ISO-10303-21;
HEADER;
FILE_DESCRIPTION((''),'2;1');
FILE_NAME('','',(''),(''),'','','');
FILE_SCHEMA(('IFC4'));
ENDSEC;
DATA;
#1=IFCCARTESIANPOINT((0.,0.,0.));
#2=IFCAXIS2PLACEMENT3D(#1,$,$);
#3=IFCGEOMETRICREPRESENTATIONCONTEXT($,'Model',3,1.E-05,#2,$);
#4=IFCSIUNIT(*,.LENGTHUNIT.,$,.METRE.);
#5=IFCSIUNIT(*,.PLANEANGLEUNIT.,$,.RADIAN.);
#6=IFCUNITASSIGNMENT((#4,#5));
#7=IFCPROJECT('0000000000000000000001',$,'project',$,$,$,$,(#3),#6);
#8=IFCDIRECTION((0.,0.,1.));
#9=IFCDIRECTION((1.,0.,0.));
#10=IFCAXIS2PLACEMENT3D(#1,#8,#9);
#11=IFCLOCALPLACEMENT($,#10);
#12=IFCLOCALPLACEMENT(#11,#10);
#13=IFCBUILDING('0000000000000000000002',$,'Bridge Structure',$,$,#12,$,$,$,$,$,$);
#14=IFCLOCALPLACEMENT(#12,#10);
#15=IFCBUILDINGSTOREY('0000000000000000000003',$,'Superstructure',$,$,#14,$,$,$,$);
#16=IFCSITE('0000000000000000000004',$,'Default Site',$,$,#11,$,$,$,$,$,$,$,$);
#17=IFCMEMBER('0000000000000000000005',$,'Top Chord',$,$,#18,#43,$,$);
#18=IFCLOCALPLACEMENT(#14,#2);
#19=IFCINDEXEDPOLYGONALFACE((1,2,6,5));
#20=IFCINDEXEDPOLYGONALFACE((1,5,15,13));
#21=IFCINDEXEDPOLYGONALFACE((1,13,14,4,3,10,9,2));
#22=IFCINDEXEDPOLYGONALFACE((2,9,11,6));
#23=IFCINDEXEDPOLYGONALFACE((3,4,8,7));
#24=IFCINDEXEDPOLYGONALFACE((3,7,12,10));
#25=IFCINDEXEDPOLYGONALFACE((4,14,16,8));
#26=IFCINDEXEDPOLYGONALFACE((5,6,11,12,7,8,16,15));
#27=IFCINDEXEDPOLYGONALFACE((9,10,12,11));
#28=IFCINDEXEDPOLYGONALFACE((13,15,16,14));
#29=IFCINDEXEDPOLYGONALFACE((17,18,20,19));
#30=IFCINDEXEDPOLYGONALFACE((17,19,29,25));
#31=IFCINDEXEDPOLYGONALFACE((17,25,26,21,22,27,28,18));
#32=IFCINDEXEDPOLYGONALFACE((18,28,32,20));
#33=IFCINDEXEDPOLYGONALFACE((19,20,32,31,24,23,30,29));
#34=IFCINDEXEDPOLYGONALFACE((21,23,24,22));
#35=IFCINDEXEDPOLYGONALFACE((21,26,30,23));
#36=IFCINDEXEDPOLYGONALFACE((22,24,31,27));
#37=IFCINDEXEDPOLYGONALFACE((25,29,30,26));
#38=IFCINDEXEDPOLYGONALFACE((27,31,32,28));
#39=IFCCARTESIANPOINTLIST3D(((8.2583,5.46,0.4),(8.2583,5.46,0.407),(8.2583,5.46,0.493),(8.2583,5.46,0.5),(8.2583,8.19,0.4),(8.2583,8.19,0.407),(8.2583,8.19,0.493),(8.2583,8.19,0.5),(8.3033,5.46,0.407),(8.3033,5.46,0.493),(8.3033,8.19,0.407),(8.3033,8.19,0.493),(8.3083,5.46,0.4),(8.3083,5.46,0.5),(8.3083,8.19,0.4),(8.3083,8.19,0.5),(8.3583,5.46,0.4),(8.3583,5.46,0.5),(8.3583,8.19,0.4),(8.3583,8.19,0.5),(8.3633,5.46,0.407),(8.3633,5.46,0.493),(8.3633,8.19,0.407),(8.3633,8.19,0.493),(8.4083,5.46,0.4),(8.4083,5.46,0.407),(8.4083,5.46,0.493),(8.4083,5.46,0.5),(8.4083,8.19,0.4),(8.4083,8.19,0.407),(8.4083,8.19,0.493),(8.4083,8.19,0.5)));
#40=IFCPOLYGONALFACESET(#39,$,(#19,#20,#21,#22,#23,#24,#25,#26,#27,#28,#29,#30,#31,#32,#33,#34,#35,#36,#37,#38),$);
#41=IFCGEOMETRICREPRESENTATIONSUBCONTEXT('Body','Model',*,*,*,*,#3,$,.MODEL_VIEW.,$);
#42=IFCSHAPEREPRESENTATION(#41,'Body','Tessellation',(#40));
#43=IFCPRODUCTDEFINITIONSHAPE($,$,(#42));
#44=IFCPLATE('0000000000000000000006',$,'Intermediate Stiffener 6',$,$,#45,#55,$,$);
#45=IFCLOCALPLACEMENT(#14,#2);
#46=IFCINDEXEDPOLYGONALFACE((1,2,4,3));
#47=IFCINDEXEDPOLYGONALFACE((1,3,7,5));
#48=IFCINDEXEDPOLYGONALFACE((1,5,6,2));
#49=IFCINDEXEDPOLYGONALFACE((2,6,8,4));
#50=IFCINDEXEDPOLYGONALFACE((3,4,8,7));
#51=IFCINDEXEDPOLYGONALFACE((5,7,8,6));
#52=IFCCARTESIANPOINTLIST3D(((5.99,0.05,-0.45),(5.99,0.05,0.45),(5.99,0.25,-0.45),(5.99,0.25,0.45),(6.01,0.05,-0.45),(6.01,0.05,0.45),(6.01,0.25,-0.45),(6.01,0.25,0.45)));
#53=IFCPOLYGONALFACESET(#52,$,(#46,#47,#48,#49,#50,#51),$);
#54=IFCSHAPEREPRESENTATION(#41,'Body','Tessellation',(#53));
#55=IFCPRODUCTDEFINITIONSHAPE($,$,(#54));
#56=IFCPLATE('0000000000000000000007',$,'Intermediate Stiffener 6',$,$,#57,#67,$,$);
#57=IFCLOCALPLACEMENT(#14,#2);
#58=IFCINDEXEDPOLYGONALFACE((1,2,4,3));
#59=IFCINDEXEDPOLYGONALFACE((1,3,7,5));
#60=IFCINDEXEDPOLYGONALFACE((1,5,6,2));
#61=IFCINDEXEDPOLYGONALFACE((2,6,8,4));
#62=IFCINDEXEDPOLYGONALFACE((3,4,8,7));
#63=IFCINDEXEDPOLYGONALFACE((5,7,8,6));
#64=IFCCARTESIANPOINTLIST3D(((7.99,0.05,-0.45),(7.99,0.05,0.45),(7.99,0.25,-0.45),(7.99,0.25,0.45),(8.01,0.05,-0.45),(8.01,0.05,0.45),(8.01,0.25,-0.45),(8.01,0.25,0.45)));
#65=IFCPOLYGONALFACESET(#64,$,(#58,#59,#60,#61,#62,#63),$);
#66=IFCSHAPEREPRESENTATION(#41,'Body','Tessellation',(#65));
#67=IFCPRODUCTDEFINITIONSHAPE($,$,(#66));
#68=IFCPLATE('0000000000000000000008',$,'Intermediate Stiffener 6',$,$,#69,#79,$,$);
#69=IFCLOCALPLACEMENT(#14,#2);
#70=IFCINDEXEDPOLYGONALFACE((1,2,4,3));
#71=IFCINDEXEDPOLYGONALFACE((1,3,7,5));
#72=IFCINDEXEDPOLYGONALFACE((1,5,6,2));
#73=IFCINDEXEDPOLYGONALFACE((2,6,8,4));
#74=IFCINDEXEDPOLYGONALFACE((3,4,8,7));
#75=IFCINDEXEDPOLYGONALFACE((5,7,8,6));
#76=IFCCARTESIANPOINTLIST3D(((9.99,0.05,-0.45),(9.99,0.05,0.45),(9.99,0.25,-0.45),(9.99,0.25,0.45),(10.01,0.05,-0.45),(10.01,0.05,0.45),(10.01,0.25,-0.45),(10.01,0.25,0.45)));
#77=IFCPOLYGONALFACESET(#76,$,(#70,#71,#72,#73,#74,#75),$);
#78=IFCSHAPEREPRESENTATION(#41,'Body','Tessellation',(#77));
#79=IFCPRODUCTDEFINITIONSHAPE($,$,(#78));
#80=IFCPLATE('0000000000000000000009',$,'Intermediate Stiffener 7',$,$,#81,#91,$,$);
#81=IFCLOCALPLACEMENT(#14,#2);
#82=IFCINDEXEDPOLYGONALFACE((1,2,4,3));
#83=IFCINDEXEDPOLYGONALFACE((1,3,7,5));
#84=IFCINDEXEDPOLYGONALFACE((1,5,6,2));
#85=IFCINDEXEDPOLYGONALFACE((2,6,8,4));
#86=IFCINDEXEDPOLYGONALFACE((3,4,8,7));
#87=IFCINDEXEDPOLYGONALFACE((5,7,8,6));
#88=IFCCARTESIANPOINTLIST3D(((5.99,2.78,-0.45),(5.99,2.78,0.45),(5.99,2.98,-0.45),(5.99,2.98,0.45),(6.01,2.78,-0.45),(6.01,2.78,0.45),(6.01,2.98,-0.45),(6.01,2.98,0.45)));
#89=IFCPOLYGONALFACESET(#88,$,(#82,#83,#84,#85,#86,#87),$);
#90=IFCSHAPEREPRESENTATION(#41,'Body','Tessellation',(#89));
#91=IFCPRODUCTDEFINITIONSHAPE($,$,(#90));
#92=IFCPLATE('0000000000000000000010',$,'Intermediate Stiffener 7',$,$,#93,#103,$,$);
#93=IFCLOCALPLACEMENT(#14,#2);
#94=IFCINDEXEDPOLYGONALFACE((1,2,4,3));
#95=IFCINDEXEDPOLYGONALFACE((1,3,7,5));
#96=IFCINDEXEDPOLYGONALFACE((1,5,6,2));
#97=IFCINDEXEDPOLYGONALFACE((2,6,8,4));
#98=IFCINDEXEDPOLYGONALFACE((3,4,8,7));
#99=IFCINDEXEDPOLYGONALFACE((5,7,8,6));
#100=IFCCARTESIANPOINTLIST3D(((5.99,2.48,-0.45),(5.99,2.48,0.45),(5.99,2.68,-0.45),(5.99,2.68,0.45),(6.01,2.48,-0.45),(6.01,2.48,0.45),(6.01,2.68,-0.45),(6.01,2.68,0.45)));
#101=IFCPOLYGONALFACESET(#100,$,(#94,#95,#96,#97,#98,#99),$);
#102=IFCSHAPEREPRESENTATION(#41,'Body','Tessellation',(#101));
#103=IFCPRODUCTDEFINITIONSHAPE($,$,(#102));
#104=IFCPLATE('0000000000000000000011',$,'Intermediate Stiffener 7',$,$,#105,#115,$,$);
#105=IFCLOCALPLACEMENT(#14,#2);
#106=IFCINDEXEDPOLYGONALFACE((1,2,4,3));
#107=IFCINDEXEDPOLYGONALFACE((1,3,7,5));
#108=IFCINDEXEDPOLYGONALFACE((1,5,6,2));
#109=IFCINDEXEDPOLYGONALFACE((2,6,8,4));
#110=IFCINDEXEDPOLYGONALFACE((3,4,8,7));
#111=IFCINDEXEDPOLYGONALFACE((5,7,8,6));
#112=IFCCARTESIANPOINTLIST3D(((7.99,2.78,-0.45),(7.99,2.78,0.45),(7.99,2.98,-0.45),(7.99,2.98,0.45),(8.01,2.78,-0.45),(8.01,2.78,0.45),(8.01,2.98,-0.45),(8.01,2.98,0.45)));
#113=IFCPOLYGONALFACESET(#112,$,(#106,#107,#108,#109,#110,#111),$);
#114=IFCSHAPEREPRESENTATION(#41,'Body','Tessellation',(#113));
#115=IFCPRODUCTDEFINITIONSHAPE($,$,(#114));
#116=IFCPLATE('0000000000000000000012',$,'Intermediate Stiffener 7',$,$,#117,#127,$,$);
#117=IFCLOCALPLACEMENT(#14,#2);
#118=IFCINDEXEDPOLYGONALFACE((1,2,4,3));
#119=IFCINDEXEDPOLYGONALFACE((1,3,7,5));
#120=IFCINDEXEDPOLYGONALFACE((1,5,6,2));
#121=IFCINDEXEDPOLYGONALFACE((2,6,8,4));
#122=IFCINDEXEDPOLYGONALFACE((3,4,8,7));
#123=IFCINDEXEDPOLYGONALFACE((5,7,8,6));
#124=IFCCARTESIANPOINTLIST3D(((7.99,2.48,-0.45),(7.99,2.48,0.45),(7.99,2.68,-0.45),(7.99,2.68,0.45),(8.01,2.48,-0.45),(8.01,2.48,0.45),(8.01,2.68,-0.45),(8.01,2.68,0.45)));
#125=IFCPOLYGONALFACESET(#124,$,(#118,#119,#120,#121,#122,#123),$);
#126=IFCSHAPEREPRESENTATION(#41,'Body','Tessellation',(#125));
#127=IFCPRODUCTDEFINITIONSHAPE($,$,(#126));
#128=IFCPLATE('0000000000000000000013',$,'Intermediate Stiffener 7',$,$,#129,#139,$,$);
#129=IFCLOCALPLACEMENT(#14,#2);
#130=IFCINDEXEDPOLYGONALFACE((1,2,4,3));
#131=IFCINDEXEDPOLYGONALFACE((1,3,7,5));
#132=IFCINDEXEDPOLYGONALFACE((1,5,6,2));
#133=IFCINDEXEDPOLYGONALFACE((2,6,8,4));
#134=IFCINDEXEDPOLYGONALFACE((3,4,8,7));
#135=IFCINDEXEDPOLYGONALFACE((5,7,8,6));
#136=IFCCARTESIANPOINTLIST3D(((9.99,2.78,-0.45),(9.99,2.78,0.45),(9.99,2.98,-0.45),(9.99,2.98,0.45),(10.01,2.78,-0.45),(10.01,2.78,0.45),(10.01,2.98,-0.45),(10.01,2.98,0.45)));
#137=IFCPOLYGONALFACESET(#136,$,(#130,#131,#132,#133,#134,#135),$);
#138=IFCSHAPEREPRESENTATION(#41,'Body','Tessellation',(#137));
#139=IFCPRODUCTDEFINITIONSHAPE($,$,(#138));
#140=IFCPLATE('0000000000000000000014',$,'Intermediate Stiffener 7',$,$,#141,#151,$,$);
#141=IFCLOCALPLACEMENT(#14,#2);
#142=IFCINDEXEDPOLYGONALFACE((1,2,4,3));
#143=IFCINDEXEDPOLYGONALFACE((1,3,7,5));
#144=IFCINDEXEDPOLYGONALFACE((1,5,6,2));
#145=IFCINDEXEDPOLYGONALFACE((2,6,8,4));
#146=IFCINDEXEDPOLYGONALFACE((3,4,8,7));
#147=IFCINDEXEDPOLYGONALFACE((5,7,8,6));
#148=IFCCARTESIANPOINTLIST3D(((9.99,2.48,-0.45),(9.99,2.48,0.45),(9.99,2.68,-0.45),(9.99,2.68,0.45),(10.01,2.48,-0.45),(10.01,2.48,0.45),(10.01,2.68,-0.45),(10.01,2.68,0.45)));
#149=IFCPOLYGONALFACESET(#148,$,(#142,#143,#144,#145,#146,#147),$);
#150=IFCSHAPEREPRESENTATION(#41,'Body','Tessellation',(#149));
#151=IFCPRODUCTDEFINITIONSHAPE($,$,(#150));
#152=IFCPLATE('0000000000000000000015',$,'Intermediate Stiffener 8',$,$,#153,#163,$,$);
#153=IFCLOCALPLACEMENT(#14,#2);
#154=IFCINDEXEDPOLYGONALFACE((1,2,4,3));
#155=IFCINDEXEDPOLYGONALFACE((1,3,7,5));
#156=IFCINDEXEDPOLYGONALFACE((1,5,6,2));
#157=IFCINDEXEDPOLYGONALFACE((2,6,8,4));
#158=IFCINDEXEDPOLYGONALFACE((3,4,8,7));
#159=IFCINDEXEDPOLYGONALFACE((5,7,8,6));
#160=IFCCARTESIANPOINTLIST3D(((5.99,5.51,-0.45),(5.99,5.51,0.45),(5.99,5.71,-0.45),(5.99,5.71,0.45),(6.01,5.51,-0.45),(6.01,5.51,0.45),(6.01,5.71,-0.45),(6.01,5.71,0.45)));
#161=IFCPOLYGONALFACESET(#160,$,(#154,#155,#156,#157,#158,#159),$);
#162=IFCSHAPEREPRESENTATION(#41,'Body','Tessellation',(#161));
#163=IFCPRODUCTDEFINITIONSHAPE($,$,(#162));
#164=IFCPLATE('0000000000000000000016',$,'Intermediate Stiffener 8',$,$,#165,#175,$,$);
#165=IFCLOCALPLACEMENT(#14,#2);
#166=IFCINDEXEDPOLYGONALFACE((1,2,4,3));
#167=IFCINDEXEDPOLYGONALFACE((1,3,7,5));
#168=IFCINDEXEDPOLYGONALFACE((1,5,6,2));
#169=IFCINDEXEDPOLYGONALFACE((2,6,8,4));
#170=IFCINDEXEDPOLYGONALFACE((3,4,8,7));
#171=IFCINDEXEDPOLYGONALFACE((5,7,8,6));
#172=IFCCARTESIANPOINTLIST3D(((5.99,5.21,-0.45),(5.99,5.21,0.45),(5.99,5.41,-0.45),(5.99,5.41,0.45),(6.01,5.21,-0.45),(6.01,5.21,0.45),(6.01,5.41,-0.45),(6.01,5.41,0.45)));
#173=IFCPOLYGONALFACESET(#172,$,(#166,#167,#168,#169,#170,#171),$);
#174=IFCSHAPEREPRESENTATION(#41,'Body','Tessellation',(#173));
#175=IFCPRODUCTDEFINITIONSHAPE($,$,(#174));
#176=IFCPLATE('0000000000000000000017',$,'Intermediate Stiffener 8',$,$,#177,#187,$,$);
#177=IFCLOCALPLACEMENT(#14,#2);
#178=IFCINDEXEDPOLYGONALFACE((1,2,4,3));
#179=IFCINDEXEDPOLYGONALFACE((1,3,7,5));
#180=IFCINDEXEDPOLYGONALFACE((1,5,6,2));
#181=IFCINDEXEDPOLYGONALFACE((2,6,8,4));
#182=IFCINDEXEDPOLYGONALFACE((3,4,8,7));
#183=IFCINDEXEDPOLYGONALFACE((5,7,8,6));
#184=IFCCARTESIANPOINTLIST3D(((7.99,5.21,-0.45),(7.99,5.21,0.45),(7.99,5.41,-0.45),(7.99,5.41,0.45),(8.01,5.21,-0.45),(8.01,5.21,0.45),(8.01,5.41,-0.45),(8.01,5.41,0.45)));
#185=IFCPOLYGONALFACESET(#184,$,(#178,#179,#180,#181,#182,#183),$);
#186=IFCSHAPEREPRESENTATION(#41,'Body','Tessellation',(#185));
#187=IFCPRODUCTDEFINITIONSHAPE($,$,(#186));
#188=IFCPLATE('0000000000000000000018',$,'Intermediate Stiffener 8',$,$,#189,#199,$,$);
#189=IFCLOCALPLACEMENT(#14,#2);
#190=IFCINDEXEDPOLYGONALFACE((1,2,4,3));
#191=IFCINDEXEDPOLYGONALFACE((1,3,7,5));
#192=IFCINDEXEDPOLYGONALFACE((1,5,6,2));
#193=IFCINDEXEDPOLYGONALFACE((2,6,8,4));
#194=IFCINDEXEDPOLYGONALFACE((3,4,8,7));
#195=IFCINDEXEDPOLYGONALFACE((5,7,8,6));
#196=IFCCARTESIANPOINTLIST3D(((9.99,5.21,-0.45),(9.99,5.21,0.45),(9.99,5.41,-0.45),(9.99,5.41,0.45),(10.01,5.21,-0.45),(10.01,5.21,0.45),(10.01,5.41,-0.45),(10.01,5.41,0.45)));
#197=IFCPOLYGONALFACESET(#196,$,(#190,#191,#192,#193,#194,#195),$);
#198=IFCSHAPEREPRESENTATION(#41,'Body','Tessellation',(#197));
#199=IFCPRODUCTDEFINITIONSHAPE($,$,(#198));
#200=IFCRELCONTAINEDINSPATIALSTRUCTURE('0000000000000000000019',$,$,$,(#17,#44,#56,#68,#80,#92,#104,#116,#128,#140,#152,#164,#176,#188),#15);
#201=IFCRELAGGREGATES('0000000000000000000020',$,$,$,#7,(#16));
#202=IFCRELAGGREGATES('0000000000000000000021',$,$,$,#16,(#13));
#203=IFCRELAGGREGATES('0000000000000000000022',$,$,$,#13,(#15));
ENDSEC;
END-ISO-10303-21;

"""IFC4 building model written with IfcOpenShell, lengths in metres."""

from ifc_helpers import new_model, si_unit, frame, origin, origin_with_axes, origin_2d_with_axis, place, context, subcontext, project, spatial, polyline, rectangle, outline, composite_profile, extrude, element, save


model = new_model("IFC4")

# Units and contexts
model_context = context("Model", 3, precision=1e-05, world=origin())
body_context = subcontext(model_context, "Body", "Model", "MODEL_VIEW")
ifc_project = project(units=[si_unit("LENGTHUNIT", "METRE"), si_unit("PLANEANGLEUNIT", "RADIAN")], contexts=[model_context])

# Site, building, storey
site_placement = place(None, origin_with_axes())
site = spatial("IfcSite", under=ifc_project, at=site_placement, Name="Default Site")
building_placement = place(site_placement, origin_with_axes())
building = spatial("IfcBuilding", under=site, at=building_placement, Name="Bridge Structure")
storey_placement = place(building_placement, origin_with_axes())
storey = spatial("IfcBuildingStorey", under=building, at=storey_placement, Name="Superstructure")

# Member
member_1_placement = place(storey_placement, frame((8.3333, 5.46, 0.45), z_axis=(0.0, 1.0, 0.0), x_axis=(-1.0, 0.0, 0.0)))
element("IfcMember", 1, at=member_1_placement, inside=storey, Name="Top Chord", context=body_context, shape_type="SweptSolid", body=[
    extrude(composite_profile([outline(polyline([(-0.025, -0.05), (-0.025, 0.05), (-0.075, 0.05), (-0.075, 0.043), (-0.03, 0.043), (-0.03, -0.043), (-0.075, -0.043), (-0.075, -0.05), (-0.025, -0.05)])), outline(polyline([(0.025, -0.05), (0.075, -0.05), (0.075, -0.043), (0.03, -0.043), (0.03, 0.043), (0.075, 0.043), (0.075, 0.05), (0.025, 0.05), (0.025, -0.05)]))]), origin_with_axes(), (0.0, 0.0, 1.0), 2.73),
])

# Plates
for number, where, z_axis, x_axis, name in (
    (2, (6.0, 0.15, -0.45), (0.0, 0.0, 1.0), (1.0, 0.0, 0.0), "Intermediate Stiffener 6"),
    (3, (8.0, 0.15, -0.45), (0.0, 0.0, 1.0), (1.0, 0.0, 0.0), "Intermediate Stiffener 6"),
    (4, (10.0, 0.15, -0.45), (0.0, 0.0, 1.0), (1.0, 0.0, 0.0), "Intermediate Stiffener 6"),
    (5, (6.0, 2.88, -0.45), (0.0, 0.0, 1.0), (1.0, 0.0, 0.0), "Intermediate Stiffener 7"),
    (6, (6.0, 2.58, -0.45), (0.0, 0.0, 1.0), (1.0, 0.0, 0.0), "Intermediate Stiffener 7"),
    (7, (8.0, 2.88, -0.45), (0.0, 0.0, 1.0), (1.0, 0.0, 0.0), "Intermediate Stiffener 7"),
    (8, (8.0, 2.58, -0.45), (0.0, 0.0, 1.0), (1.0, 0.0, 0.0), "Intermediate Stiffener 7"),
    (9, (10.0, 2.88, -0.45), (0.0, 0.0, 1.0), (1.0, 0.0, 0.0), "Intermediate Stiffener 7"),
    (10, (10.0, 2.58, -0.45), (0.0, 0.0, 1.0), (1.0, 0.0, 0.0), "Intermediate Stiffener 7"),
    (11, (6.0, 5.61, -0.45), (0.0, 0.0, 1.0), (1.0, 0.0, 0.0), "Intermediate Stiffener 8"),
    (12, (6.0, 5.31, -0.45), (0.0, 0.0, 1.0), (1.0, 0.0, 0.0), "Intermediate Stiffener 8"),
    (13, (8.0, 5.31, -0.45), (0.0, 0.0, 1.0), (1.0, 0.0, 0.0), "Intermediate Stiffener 8"),
    (14, (10.0, 5.31, -0.45), (0.0, 0.0, 1.0), (1.0, 0.0, 0.0), "Intermediate Stiffener 8"),
):
    element("IfcPlate", number, at=place(storey_placement, frame(where, z_axis=z_axis, x_axis=x_axis)), inside=storey, Name=name, context=body_context, shape_type="SweptSolid", body=[
        extrude(rectangle(XDim=0.02, YDim=0.2, at=origin_2d_with_axis()), origin_with_axes(), (0.0, 0.0, 1.0), 0.9),
    ])

save(model, "model.ifc")
